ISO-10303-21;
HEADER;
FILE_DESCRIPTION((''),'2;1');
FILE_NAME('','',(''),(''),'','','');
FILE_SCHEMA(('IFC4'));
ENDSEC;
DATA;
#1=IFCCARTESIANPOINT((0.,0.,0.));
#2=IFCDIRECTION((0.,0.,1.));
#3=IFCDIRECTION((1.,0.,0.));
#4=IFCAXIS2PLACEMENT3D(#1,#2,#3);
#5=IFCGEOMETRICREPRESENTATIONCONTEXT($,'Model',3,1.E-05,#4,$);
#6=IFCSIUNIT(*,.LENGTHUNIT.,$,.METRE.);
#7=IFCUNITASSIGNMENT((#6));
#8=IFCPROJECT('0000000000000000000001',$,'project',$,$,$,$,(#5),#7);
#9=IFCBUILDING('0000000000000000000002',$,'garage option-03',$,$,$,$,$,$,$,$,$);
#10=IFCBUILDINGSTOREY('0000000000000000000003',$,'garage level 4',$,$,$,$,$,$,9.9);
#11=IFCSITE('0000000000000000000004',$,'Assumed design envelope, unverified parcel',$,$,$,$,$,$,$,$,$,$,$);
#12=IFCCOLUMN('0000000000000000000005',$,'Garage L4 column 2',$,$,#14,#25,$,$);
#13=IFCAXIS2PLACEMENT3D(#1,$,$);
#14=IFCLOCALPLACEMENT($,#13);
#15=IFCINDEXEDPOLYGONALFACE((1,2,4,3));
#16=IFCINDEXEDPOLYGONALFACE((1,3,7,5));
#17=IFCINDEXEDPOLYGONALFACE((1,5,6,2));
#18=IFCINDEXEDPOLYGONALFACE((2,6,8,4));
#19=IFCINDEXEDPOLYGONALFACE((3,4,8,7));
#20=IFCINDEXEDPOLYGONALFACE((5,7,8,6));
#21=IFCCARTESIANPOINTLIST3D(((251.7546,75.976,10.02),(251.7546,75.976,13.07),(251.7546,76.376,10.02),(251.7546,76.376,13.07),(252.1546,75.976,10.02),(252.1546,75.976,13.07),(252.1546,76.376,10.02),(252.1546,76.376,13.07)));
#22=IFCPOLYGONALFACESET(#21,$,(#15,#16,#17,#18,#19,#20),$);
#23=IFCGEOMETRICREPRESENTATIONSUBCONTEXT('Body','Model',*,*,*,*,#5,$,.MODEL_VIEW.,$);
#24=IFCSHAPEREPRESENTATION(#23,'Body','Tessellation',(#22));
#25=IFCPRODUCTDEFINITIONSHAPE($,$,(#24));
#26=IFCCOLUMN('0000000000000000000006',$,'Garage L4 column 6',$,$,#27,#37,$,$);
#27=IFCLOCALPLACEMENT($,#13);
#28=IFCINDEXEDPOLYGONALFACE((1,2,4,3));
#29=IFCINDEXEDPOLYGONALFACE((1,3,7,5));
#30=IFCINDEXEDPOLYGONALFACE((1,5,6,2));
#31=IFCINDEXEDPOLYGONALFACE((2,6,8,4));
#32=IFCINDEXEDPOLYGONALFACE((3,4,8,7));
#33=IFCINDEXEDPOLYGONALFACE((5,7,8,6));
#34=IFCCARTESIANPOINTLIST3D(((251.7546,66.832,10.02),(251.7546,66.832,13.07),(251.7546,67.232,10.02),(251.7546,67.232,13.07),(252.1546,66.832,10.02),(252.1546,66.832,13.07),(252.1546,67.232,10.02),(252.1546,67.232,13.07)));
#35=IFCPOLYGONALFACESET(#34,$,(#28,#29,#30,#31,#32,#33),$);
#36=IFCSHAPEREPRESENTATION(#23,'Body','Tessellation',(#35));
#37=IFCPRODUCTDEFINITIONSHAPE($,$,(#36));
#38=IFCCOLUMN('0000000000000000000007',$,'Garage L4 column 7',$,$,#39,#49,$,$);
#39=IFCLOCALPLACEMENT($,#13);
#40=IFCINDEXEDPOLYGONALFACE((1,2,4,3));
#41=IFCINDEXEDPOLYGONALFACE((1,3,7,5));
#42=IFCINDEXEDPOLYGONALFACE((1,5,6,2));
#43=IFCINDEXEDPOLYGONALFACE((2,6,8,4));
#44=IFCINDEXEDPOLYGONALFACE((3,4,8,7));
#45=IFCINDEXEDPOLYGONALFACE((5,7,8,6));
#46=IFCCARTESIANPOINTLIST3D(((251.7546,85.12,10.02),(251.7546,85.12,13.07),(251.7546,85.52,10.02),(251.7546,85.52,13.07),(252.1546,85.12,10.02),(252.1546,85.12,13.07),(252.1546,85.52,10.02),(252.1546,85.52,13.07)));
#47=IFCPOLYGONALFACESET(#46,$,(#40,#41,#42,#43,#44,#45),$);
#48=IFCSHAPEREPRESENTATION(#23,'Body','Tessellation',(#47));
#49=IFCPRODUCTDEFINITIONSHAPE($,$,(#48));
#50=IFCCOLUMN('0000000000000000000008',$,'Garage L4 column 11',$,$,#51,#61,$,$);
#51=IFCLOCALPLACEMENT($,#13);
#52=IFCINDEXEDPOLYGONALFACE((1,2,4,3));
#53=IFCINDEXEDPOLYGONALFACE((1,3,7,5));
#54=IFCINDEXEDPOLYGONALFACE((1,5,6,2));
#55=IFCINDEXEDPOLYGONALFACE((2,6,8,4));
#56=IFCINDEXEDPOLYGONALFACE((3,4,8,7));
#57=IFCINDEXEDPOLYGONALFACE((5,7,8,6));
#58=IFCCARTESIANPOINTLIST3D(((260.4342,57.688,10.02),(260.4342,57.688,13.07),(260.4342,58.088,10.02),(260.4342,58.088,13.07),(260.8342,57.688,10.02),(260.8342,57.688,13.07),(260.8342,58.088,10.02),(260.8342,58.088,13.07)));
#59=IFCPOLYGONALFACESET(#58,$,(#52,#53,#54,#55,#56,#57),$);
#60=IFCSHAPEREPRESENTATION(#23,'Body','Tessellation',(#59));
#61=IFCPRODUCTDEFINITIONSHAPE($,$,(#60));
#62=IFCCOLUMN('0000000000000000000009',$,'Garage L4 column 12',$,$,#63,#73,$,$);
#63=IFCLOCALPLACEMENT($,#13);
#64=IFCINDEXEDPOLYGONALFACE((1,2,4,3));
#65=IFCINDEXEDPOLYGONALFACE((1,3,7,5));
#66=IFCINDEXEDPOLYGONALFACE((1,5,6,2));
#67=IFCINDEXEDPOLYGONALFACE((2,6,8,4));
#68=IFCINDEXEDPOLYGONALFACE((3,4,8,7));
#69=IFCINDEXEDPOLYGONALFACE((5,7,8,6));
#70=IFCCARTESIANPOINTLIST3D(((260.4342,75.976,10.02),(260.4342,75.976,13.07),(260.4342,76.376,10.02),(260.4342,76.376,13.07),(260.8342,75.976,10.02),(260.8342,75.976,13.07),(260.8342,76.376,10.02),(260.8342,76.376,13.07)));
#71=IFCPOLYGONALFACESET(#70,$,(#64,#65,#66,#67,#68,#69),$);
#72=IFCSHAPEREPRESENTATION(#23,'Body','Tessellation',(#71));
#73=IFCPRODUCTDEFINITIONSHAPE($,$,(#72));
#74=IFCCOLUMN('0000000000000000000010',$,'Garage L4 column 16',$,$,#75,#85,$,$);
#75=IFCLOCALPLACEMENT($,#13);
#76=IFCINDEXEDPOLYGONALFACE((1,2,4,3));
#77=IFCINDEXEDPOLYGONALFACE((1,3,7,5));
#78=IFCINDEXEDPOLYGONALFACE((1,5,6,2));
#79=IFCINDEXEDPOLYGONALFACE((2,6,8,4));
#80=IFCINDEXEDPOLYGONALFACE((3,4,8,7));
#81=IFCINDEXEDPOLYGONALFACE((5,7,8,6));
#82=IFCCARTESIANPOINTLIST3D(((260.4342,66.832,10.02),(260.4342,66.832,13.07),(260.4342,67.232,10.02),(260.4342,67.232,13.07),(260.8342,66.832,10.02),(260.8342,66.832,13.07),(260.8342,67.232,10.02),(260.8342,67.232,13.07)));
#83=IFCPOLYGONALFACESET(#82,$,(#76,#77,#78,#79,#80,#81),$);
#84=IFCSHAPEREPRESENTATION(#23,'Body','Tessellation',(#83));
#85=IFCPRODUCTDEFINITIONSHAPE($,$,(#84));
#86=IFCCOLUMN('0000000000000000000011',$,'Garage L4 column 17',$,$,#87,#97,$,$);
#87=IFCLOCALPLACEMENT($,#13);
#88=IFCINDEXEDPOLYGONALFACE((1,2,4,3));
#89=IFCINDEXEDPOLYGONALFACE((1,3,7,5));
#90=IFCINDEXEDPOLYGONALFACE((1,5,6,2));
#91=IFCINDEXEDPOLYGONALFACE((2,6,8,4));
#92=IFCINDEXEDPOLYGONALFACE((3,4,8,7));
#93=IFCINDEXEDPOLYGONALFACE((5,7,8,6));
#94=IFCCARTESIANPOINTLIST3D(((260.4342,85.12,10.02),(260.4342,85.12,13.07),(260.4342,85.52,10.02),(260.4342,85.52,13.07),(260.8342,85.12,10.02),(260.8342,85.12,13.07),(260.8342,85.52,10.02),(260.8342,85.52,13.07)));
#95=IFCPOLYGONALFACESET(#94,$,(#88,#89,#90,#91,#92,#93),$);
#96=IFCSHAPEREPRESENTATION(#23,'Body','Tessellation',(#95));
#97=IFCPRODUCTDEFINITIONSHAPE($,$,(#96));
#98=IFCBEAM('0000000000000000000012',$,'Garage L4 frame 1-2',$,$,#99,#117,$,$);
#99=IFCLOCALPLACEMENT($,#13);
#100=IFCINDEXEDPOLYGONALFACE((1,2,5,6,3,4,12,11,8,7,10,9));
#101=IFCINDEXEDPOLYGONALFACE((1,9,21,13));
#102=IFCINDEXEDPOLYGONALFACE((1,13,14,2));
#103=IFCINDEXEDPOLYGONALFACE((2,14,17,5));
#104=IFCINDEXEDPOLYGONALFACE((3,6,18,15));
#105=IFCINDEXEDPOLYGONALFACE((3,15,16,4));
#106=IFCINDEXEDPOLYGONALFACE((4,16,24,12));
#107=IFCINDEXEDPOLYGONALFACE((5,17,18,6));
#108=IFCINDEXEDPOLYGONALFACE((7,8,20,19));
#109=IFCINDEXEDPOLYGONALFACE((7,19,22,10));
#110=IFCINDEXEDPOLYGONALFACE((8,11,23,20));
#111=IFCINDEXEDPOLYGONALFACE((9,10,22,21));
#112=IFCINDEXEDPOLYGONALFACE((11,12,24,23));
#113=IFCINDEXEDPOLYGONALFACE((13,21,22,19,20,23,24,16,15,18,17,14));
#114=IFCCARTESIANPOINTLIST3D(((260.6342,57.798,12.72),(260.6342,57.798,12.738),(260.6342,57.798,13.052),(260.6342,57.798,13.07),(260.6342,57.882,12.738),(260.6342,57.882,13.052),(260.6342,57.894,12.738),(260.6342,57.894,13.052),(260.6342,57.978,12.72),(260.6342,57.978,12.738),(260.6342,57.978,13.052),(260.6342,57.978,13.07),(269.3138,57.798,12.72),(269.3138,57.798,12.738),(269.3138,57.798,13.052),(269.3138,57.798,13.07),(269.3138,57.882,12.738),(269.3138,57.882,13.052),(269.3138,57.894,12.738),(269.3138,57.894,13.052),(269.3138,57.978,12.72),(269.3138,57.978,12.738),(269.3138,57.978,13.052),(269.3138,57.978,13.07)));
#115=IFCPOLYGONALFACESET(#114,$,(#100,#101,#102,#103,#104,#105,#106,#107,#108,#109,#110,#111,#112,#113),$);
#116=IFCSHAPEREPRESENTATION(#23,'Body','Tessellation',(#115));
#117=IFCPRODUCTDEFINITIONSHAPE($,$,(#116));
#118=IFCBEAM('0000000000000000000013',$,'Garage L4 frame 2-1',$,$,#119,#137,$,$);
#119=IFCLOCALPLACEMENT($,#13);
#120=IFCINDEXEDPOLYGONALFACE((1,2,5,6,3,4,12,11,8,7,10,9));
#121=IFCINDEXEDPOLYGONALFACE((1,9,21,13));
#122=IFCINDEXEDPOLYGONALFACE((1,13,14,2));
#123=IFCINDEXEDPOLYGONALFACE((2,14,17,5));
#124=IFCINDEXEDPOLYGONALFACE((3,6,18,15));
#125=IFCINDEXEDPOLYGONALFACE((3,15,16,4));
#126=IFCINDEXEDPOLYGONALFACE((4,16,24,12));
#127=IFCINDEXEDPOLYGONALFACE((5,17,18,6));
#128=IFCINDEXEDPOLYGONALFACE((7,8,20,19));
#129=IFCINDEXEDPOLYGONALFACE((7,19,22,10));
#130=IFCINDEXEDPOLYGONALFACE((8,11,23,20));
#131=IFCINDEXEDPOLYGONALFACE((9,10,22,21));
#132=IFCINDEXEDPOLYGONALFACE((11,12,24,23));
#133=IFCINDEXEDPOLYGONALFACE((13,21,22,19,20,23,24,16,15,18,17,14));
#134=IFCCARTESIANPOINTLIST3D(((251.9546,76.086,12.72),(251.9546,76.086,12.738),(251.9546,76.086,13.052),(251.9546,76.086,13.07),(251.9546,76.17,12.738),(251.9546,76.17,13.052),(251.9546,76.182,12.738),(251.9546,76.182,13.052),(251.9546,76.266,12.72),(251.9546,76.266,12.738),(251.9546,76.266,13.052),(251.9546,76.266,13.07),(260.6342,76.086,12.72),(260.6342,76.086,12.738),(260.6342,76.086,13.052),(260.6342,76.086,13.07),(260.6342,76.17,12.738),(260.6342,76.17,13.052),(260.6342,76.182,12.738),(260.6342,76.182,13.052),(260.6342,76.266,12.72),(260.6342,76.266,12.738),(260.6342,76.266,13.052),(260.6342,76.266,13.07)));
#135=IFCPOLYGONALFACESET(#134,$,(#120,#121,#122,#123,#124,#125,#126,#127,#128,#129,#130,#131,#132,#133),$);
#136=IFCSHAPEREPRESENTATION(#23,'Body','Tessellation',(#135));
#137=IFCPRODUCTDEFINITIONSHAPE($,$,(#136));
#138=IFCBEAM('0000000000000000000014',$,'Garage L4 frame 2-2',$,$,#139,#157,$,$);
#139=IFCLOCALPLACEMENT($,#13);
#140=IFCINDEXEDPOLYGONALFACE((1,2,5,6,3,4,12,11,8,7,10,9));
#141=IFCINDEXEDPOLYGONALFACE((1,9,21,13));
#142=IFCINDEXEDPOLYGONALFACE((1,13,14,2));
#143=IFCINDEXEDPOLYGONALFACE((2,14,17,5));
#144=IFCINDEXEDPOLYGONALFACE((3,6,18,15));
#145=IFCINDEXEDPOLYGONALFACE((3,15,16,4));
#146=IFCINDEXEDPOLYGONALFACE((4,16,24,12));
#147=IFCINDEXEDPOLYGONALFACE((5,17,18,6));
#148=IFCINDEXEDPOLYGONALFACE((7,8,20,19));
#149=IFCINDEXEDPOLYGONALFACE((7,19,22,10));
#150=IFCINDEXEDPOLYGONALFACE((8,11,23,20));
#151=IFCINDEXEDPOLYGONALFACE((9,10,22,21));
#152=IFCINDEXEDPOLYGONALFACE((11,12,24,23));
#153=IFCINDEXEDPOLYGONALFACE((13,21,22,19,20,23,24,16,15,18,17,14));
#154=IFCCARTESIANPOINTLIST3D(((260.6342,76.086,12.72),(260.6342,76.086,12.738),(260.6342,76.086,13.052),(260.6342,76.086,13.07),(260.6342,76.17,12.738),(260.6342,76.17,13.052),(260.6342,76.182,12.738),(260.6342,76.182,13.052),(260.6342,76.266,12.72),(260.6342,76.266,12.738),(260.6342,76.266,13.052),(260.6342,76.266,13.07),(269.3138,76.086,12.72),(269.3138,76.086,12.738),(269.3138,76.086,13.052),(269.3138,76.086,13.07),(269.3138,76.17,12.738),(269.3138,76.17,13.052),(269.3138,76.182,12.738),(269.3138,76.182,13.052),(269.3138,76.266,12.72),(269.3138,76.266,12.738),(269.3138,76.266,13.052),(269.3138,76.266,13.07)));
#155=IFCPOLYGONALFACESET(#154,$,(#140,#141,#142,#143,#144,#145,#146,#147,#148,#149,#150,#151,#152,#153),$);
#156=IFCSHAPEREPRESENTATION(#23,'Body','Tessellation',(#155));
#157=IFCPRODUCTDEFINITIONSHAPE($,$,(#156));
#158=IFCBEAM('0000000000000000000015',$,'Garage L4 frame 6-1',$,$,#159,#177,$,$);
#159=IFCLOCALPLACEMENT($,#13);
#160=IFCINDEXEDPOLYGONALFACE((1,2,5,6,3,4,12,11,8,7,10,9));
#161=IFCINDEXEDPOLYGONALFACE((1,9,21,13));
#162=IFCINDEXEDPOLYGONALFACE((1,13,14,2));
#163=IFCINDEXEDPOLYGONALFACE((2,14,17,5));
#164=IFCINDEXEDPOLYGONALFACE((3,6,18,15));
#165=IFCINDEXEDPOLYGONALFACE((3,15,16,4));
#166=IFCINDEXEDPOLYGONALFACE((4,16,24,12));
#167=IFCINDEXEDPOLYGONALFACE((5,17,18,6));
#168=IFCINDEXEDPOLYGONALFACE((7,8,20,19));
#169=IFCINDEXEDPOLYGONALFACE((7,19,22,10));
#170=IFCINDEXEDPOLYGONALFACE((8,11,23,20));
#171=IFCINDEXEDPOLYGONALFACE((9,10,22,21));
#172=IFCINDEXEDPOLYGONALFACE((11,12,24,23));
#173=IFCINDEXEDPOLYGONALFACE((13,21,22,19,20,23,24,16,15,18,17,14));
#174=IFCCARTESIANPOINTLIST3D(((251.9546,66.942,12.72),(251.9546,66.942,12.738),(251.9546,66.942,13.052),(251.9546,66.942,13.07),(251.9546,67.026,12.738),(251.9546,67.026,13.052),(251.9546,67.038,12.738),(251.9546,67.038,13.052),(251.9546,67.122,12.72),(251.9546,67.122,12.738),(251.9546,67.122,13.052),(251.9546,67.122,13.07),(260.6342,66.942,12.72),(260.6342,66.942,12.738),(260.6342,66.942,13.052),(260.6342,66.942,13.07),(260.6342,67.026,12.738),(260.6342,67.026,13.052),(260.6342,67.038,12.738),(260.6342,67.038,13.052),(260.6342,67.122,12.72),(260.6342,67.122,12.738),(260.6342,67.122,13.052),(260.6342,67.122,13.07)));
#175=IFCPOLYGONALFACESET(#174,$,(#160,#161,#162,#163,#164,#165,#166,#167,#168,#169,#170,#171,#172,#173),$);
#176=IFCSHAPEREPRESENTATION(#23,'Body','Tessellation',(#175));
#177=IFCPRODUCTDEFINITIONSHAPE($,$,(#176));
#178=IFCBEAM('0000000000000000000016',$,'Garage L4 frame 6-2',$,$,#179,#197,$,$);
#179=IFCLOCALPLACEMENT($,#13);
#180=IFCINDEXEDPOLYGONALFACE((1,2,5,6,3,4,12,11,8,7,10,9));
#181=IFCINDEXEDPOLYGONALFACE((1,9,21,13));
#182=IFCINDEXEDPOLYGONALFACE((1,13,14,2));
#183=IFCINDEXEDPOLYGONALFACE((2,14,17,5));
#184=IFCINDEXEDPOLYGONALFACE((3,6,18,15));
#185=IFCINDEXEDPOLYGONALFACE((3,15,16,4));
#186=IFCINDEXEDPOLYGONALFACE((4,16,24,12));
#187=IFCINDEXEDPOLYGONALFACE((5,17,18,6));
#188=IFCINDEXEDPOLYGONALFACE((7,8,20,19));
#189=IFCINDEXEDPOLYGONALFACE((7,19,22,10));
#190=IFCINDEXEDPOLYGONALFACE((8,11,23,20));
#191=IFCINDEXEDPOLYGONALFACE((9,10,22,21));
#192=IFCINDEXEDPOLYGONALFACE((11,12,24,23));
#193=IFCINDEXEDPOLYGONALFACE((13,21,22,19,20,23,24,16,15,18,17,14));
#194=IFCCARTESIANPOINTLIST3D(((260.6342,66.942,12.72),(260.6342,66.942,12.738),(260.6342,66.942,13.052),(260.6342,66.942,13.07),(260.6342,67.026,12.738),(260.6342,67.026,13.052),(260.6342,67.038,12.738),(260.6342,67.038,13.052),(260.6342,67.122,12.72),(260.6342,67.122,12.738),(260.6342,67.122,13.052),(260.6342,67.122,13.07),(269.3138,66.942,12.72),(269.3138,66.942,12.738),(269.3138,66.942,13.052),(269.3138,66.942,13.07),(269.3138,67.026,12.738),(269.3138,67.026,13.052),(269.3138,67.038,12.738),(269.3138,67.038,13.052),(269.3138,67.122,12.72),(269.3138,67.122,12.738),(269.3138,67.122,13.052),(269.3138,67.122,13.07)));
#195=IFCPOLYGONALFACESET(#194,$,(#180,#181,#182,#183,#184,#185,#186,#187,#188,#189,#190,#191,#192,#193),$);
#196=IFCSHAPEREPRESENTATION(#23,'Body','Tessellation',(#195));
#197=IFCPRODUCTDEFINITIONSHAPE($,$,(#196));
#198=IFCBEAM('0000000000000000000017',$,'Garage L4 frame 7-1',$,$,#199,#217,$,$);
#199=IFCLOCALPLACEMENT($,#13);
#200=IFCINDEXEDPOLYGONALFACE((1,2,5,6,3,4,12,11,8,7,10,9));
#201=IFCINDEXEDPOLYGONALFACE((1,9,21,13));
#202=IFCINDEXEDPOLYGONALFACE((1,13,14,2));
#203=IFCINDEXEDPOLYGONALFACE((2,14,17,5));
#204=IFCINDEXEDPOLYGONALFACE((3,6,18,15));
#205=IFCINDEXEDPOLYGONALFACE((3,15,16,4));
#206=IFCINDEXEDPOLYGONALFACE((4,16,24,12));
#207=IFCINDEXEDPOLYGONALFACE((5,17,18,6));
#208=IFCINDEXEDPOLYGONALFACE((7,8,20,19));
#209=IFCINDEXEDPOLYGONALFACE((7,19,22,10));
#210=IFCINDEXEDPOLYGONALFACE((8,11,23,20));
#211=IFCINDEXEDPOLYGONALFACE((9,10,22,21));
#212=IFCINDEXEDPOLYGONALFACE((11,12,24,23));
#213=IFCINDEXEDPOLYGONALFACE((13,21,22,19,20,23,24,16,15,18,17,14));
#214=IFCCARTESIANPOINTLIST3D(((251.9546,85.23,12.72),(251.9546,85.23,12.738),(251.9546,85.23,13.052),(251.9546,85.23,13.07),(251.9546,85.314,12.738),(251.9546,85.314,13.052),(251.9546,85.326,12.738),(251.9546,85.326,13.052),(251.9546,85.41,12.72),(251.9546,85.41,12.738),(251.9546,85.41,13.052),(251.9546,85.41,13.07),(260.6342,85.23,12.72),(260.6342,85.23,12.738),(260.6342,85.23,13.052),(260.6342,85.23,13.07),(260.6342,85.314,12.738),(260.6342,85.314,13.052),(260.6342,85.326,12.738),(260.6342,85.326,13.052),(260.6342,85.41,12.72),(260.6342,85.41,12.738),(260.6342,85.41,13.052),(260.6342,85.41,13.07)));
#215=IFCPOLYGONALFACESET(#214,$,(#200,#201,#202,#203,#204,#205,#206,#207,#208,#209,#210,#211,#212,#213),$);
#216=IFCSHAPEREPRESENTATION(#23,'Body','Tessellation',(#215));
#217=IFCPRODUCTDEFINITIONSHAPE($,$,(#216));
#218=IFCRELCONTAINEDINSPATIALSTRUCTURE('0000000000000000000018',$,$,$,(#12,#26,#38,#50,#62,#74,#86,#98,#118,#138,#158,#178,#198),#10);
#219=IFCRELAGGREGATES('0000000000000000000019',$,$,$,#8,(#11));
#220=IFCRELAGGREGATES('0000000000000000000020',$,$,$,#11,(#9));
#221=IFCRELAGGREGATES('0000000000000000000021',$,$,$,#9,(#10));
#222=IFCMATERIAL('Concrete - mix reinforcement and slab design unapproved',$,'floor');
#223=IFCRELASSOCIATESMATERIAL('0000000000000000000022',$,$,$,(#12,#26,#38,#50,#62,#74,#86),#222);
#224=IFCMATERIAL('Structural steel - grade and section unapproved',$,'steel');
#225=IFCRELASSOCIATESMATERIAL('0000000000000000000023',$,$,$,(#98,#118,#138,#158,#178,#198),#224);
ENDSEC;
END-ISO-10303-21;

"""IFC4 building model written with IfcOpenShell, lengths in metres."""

from ifc_helpers import new_model, si_unit, frame, origin_with_axes, place, context, subcontext, project, spatial, rectangle, i_section, extrude, material, element, save


model = new_model("IFC4")

# Units and contexts
model_context = context("Model", 3, precision=1e-05, world=origin_with_axes())
body_context = subcontext(model_context, "Body", "Model", "MODEL_VIEW")
ifc_project = project(units=[si_unit("LENGTHUNIT", "METRE")], contexts=[model_context])

# Site, building, storey
site = spatial("IfcSite", under=ifc_project, Name="Assumed design envelope, unverified parcel")
building = spatial("IfcBuilding", under=site, Name="garage option-03")
storey = spatial("IfcBuildingStorey", under=building, Name="garage level 4", Elevation=9.9)

# Columns
ifc_material_1 = material(Name="Concrete - mix reinforcement and slab design unapproved", Category="floor")
for number, where, z_axis, x_axis, name in (
    (1, (251.9546, 76.176, 10.02), (0.0, 0.0, 1.0), (1.0, 0.0, 0.0), "Garage L4 column 2"),
    (2, (251.9546, 67.032, 10.02), (0.0, 0.0, 1.0), (1.0, 0.0, 0.0), "Garage L4 column 6"),
    (3, (251.9546, 85.32, 10.02), (0.0, 0.0, 1.0), (1.0, 0.0, 0.0), "Garage L4 column 7"),
    (4, (260.6342, 57.888, 10.02), (0.0, 0.0, 1.0), (1.0, 0.0, 0.0), "Garage L4 column 11"),
    (5, (260.6342, 76.176, 10.02), (0.0, 0.0, 1.0), (1.0, 0.0, 0.0), "Garage L4 column 12"),
    (6, (260.6342, 67.032, 10.02), (0.0, 0.0, 1.0), (1.0, 0.0, 0.0), "Garage L4 column 16"),
    (7, (260.6342, 85.32, 10.02), (0.0, 0.0, 1.0), (1.0, 0.0, 0.0), "Garage L4 column 17"),
):
    element("IfcColumn", number, at=place(None, frame(where, z_axis=z_axis, x_axis=x_axis)), inside=storey, material=ifc_material_1, Name=name, context=body_context, shape_type="SweptSolid", body=[
        extrude(rectangle(XDim=0.4, YDim=0.4), origin_with_axes(), (0.0, 0.0, 1.0), 3.05),
    ])

# Beams
ifc_material_2 = material(Name="Structural steel - grade and section unapproved", Category="steel")
beam_1_placement = place(None, frame((260.6342, 57.888, 12.895), z_axis=(1.0, 0.0, 0.0), x_axis=(0.0, 1.0, 0.0)))
element("IfcBeam", 8, at=beam_1_placement, inside=storey, material=ifc_material_2, Name="Garage L4 frame 1-2", context=body_context, shape_type="SweptSolid", body=[
    extrude(i_section(OverallWidth=0.18, OverallDepth=0.35, WebThickness=0.012, FlangeThickness=0.018, FilletRadius=0.0), origin_with_axes(), (0.0, 0.0, 1.0), 8.6796),
])
beam_2_placement = place(None, frame((251.9546, 76.176, 12.895), z_axis=(1.0, 0.0, 0.0), x_axis=(0.0, 1.0, 0.0)))
element("IfcBeam", 9, at=beam_2_placement, inside=storey, material=ifc_material_2, Name="Garage L4 frame 2-1", context=body_context, shape_type="SweptSolid", body=[
    extrude(i_section(OverallWidth=0.18, OverallDepth=0.35, WebThickness=0.012, FlangeThickness=0.018, FilletRadius=0.0), origin_with_axes(), (0.0, 0.0, 1.0), 8.6796),
])
beam_3_placement = place(None, frame((260.6342, 76.176, 12.895), z_axis=(1.0, 0.0, 0.0), x_axis=(0.0, 1.0, 0.0)))
element("IfcBeam", 10, at=beam_3_placement, inside=storey, material=ifc_material_2, Name="Garage L4 frame 2-2", context=body_context, shape_type="SweptSolid", body=[
    extrude(i_section(OverallWidth=0.18, OverallDepth=0.35, WebThickness=0.012, FlangeThickness=0.018, FilletRadius=0.0), origin_with_axes(), (0.0, 0.0, 1.0), 8.6796),
])
beam_4_placement = place(None, frame((251.9546, 67.032, 12.895), z_axis=(1.0, 0.0, 0.0), x_axis=(0.0, 1.0, 0.0)))
element("IfcBeam", 11, at=beam_4_placement, inside=storey, material=ifc_material_2, Name="Garage L4 frame 6-1", context=body_context, shape_type="SweptSolid", body=[
    extrude(i_section(OverallWidth=0.18, OverallDepth=0.35, WebThickness=0.012, FlangeThickness=0.018, FilletRadius=0.0), origin_with_axes(), (0.0, 0.0, 1.0), 8.6796),
])
beam_5_placement = place(None, frame((260.6342, 67.032, 12.895), z_axis=(1.0, 0.0, 0.0), x_axis=(0.0, 1.0, 0.0)))
element("IfcBeam", 12, at=beam_5_placement, inside=storey, material=ifc_material_2, Name="Garage L4 frame 6-2", context=body_context, shape_type="SweptSolid", body=[
    extrude(i_section(OverallWidth=0.18, OverallDepth=0.35, WebThickness=0.012, FlangeThickness=0.018, FilletRadius=0.0), origin_with_axes(), (0.0, 0.0, 1.0), 8.6796),
])
beam_6_placement = place(None, frame((251.9546, 85.32, 12.895), z_axis=(1.0, 0.0, 0.0), x_axis=(0.0, 1.0, 0.0)))
element("IfcBeam", 13, at=beam_6_placement, inside=storey, material=ifc_material_2, Name="Garage L4 frame 7-1", context=body_context, shape_type="SweptSolid", body=[
    extrude(i_section(OverallWidth=0.18, OverallDepth=0.35, WebThickness=0.012, FlangeThickness=0.018, FilletRadius=0.0), origin_with_axes(), (0.0, 0.0, 1.0), 8.6796),
])

save(model, "model.ifc")
